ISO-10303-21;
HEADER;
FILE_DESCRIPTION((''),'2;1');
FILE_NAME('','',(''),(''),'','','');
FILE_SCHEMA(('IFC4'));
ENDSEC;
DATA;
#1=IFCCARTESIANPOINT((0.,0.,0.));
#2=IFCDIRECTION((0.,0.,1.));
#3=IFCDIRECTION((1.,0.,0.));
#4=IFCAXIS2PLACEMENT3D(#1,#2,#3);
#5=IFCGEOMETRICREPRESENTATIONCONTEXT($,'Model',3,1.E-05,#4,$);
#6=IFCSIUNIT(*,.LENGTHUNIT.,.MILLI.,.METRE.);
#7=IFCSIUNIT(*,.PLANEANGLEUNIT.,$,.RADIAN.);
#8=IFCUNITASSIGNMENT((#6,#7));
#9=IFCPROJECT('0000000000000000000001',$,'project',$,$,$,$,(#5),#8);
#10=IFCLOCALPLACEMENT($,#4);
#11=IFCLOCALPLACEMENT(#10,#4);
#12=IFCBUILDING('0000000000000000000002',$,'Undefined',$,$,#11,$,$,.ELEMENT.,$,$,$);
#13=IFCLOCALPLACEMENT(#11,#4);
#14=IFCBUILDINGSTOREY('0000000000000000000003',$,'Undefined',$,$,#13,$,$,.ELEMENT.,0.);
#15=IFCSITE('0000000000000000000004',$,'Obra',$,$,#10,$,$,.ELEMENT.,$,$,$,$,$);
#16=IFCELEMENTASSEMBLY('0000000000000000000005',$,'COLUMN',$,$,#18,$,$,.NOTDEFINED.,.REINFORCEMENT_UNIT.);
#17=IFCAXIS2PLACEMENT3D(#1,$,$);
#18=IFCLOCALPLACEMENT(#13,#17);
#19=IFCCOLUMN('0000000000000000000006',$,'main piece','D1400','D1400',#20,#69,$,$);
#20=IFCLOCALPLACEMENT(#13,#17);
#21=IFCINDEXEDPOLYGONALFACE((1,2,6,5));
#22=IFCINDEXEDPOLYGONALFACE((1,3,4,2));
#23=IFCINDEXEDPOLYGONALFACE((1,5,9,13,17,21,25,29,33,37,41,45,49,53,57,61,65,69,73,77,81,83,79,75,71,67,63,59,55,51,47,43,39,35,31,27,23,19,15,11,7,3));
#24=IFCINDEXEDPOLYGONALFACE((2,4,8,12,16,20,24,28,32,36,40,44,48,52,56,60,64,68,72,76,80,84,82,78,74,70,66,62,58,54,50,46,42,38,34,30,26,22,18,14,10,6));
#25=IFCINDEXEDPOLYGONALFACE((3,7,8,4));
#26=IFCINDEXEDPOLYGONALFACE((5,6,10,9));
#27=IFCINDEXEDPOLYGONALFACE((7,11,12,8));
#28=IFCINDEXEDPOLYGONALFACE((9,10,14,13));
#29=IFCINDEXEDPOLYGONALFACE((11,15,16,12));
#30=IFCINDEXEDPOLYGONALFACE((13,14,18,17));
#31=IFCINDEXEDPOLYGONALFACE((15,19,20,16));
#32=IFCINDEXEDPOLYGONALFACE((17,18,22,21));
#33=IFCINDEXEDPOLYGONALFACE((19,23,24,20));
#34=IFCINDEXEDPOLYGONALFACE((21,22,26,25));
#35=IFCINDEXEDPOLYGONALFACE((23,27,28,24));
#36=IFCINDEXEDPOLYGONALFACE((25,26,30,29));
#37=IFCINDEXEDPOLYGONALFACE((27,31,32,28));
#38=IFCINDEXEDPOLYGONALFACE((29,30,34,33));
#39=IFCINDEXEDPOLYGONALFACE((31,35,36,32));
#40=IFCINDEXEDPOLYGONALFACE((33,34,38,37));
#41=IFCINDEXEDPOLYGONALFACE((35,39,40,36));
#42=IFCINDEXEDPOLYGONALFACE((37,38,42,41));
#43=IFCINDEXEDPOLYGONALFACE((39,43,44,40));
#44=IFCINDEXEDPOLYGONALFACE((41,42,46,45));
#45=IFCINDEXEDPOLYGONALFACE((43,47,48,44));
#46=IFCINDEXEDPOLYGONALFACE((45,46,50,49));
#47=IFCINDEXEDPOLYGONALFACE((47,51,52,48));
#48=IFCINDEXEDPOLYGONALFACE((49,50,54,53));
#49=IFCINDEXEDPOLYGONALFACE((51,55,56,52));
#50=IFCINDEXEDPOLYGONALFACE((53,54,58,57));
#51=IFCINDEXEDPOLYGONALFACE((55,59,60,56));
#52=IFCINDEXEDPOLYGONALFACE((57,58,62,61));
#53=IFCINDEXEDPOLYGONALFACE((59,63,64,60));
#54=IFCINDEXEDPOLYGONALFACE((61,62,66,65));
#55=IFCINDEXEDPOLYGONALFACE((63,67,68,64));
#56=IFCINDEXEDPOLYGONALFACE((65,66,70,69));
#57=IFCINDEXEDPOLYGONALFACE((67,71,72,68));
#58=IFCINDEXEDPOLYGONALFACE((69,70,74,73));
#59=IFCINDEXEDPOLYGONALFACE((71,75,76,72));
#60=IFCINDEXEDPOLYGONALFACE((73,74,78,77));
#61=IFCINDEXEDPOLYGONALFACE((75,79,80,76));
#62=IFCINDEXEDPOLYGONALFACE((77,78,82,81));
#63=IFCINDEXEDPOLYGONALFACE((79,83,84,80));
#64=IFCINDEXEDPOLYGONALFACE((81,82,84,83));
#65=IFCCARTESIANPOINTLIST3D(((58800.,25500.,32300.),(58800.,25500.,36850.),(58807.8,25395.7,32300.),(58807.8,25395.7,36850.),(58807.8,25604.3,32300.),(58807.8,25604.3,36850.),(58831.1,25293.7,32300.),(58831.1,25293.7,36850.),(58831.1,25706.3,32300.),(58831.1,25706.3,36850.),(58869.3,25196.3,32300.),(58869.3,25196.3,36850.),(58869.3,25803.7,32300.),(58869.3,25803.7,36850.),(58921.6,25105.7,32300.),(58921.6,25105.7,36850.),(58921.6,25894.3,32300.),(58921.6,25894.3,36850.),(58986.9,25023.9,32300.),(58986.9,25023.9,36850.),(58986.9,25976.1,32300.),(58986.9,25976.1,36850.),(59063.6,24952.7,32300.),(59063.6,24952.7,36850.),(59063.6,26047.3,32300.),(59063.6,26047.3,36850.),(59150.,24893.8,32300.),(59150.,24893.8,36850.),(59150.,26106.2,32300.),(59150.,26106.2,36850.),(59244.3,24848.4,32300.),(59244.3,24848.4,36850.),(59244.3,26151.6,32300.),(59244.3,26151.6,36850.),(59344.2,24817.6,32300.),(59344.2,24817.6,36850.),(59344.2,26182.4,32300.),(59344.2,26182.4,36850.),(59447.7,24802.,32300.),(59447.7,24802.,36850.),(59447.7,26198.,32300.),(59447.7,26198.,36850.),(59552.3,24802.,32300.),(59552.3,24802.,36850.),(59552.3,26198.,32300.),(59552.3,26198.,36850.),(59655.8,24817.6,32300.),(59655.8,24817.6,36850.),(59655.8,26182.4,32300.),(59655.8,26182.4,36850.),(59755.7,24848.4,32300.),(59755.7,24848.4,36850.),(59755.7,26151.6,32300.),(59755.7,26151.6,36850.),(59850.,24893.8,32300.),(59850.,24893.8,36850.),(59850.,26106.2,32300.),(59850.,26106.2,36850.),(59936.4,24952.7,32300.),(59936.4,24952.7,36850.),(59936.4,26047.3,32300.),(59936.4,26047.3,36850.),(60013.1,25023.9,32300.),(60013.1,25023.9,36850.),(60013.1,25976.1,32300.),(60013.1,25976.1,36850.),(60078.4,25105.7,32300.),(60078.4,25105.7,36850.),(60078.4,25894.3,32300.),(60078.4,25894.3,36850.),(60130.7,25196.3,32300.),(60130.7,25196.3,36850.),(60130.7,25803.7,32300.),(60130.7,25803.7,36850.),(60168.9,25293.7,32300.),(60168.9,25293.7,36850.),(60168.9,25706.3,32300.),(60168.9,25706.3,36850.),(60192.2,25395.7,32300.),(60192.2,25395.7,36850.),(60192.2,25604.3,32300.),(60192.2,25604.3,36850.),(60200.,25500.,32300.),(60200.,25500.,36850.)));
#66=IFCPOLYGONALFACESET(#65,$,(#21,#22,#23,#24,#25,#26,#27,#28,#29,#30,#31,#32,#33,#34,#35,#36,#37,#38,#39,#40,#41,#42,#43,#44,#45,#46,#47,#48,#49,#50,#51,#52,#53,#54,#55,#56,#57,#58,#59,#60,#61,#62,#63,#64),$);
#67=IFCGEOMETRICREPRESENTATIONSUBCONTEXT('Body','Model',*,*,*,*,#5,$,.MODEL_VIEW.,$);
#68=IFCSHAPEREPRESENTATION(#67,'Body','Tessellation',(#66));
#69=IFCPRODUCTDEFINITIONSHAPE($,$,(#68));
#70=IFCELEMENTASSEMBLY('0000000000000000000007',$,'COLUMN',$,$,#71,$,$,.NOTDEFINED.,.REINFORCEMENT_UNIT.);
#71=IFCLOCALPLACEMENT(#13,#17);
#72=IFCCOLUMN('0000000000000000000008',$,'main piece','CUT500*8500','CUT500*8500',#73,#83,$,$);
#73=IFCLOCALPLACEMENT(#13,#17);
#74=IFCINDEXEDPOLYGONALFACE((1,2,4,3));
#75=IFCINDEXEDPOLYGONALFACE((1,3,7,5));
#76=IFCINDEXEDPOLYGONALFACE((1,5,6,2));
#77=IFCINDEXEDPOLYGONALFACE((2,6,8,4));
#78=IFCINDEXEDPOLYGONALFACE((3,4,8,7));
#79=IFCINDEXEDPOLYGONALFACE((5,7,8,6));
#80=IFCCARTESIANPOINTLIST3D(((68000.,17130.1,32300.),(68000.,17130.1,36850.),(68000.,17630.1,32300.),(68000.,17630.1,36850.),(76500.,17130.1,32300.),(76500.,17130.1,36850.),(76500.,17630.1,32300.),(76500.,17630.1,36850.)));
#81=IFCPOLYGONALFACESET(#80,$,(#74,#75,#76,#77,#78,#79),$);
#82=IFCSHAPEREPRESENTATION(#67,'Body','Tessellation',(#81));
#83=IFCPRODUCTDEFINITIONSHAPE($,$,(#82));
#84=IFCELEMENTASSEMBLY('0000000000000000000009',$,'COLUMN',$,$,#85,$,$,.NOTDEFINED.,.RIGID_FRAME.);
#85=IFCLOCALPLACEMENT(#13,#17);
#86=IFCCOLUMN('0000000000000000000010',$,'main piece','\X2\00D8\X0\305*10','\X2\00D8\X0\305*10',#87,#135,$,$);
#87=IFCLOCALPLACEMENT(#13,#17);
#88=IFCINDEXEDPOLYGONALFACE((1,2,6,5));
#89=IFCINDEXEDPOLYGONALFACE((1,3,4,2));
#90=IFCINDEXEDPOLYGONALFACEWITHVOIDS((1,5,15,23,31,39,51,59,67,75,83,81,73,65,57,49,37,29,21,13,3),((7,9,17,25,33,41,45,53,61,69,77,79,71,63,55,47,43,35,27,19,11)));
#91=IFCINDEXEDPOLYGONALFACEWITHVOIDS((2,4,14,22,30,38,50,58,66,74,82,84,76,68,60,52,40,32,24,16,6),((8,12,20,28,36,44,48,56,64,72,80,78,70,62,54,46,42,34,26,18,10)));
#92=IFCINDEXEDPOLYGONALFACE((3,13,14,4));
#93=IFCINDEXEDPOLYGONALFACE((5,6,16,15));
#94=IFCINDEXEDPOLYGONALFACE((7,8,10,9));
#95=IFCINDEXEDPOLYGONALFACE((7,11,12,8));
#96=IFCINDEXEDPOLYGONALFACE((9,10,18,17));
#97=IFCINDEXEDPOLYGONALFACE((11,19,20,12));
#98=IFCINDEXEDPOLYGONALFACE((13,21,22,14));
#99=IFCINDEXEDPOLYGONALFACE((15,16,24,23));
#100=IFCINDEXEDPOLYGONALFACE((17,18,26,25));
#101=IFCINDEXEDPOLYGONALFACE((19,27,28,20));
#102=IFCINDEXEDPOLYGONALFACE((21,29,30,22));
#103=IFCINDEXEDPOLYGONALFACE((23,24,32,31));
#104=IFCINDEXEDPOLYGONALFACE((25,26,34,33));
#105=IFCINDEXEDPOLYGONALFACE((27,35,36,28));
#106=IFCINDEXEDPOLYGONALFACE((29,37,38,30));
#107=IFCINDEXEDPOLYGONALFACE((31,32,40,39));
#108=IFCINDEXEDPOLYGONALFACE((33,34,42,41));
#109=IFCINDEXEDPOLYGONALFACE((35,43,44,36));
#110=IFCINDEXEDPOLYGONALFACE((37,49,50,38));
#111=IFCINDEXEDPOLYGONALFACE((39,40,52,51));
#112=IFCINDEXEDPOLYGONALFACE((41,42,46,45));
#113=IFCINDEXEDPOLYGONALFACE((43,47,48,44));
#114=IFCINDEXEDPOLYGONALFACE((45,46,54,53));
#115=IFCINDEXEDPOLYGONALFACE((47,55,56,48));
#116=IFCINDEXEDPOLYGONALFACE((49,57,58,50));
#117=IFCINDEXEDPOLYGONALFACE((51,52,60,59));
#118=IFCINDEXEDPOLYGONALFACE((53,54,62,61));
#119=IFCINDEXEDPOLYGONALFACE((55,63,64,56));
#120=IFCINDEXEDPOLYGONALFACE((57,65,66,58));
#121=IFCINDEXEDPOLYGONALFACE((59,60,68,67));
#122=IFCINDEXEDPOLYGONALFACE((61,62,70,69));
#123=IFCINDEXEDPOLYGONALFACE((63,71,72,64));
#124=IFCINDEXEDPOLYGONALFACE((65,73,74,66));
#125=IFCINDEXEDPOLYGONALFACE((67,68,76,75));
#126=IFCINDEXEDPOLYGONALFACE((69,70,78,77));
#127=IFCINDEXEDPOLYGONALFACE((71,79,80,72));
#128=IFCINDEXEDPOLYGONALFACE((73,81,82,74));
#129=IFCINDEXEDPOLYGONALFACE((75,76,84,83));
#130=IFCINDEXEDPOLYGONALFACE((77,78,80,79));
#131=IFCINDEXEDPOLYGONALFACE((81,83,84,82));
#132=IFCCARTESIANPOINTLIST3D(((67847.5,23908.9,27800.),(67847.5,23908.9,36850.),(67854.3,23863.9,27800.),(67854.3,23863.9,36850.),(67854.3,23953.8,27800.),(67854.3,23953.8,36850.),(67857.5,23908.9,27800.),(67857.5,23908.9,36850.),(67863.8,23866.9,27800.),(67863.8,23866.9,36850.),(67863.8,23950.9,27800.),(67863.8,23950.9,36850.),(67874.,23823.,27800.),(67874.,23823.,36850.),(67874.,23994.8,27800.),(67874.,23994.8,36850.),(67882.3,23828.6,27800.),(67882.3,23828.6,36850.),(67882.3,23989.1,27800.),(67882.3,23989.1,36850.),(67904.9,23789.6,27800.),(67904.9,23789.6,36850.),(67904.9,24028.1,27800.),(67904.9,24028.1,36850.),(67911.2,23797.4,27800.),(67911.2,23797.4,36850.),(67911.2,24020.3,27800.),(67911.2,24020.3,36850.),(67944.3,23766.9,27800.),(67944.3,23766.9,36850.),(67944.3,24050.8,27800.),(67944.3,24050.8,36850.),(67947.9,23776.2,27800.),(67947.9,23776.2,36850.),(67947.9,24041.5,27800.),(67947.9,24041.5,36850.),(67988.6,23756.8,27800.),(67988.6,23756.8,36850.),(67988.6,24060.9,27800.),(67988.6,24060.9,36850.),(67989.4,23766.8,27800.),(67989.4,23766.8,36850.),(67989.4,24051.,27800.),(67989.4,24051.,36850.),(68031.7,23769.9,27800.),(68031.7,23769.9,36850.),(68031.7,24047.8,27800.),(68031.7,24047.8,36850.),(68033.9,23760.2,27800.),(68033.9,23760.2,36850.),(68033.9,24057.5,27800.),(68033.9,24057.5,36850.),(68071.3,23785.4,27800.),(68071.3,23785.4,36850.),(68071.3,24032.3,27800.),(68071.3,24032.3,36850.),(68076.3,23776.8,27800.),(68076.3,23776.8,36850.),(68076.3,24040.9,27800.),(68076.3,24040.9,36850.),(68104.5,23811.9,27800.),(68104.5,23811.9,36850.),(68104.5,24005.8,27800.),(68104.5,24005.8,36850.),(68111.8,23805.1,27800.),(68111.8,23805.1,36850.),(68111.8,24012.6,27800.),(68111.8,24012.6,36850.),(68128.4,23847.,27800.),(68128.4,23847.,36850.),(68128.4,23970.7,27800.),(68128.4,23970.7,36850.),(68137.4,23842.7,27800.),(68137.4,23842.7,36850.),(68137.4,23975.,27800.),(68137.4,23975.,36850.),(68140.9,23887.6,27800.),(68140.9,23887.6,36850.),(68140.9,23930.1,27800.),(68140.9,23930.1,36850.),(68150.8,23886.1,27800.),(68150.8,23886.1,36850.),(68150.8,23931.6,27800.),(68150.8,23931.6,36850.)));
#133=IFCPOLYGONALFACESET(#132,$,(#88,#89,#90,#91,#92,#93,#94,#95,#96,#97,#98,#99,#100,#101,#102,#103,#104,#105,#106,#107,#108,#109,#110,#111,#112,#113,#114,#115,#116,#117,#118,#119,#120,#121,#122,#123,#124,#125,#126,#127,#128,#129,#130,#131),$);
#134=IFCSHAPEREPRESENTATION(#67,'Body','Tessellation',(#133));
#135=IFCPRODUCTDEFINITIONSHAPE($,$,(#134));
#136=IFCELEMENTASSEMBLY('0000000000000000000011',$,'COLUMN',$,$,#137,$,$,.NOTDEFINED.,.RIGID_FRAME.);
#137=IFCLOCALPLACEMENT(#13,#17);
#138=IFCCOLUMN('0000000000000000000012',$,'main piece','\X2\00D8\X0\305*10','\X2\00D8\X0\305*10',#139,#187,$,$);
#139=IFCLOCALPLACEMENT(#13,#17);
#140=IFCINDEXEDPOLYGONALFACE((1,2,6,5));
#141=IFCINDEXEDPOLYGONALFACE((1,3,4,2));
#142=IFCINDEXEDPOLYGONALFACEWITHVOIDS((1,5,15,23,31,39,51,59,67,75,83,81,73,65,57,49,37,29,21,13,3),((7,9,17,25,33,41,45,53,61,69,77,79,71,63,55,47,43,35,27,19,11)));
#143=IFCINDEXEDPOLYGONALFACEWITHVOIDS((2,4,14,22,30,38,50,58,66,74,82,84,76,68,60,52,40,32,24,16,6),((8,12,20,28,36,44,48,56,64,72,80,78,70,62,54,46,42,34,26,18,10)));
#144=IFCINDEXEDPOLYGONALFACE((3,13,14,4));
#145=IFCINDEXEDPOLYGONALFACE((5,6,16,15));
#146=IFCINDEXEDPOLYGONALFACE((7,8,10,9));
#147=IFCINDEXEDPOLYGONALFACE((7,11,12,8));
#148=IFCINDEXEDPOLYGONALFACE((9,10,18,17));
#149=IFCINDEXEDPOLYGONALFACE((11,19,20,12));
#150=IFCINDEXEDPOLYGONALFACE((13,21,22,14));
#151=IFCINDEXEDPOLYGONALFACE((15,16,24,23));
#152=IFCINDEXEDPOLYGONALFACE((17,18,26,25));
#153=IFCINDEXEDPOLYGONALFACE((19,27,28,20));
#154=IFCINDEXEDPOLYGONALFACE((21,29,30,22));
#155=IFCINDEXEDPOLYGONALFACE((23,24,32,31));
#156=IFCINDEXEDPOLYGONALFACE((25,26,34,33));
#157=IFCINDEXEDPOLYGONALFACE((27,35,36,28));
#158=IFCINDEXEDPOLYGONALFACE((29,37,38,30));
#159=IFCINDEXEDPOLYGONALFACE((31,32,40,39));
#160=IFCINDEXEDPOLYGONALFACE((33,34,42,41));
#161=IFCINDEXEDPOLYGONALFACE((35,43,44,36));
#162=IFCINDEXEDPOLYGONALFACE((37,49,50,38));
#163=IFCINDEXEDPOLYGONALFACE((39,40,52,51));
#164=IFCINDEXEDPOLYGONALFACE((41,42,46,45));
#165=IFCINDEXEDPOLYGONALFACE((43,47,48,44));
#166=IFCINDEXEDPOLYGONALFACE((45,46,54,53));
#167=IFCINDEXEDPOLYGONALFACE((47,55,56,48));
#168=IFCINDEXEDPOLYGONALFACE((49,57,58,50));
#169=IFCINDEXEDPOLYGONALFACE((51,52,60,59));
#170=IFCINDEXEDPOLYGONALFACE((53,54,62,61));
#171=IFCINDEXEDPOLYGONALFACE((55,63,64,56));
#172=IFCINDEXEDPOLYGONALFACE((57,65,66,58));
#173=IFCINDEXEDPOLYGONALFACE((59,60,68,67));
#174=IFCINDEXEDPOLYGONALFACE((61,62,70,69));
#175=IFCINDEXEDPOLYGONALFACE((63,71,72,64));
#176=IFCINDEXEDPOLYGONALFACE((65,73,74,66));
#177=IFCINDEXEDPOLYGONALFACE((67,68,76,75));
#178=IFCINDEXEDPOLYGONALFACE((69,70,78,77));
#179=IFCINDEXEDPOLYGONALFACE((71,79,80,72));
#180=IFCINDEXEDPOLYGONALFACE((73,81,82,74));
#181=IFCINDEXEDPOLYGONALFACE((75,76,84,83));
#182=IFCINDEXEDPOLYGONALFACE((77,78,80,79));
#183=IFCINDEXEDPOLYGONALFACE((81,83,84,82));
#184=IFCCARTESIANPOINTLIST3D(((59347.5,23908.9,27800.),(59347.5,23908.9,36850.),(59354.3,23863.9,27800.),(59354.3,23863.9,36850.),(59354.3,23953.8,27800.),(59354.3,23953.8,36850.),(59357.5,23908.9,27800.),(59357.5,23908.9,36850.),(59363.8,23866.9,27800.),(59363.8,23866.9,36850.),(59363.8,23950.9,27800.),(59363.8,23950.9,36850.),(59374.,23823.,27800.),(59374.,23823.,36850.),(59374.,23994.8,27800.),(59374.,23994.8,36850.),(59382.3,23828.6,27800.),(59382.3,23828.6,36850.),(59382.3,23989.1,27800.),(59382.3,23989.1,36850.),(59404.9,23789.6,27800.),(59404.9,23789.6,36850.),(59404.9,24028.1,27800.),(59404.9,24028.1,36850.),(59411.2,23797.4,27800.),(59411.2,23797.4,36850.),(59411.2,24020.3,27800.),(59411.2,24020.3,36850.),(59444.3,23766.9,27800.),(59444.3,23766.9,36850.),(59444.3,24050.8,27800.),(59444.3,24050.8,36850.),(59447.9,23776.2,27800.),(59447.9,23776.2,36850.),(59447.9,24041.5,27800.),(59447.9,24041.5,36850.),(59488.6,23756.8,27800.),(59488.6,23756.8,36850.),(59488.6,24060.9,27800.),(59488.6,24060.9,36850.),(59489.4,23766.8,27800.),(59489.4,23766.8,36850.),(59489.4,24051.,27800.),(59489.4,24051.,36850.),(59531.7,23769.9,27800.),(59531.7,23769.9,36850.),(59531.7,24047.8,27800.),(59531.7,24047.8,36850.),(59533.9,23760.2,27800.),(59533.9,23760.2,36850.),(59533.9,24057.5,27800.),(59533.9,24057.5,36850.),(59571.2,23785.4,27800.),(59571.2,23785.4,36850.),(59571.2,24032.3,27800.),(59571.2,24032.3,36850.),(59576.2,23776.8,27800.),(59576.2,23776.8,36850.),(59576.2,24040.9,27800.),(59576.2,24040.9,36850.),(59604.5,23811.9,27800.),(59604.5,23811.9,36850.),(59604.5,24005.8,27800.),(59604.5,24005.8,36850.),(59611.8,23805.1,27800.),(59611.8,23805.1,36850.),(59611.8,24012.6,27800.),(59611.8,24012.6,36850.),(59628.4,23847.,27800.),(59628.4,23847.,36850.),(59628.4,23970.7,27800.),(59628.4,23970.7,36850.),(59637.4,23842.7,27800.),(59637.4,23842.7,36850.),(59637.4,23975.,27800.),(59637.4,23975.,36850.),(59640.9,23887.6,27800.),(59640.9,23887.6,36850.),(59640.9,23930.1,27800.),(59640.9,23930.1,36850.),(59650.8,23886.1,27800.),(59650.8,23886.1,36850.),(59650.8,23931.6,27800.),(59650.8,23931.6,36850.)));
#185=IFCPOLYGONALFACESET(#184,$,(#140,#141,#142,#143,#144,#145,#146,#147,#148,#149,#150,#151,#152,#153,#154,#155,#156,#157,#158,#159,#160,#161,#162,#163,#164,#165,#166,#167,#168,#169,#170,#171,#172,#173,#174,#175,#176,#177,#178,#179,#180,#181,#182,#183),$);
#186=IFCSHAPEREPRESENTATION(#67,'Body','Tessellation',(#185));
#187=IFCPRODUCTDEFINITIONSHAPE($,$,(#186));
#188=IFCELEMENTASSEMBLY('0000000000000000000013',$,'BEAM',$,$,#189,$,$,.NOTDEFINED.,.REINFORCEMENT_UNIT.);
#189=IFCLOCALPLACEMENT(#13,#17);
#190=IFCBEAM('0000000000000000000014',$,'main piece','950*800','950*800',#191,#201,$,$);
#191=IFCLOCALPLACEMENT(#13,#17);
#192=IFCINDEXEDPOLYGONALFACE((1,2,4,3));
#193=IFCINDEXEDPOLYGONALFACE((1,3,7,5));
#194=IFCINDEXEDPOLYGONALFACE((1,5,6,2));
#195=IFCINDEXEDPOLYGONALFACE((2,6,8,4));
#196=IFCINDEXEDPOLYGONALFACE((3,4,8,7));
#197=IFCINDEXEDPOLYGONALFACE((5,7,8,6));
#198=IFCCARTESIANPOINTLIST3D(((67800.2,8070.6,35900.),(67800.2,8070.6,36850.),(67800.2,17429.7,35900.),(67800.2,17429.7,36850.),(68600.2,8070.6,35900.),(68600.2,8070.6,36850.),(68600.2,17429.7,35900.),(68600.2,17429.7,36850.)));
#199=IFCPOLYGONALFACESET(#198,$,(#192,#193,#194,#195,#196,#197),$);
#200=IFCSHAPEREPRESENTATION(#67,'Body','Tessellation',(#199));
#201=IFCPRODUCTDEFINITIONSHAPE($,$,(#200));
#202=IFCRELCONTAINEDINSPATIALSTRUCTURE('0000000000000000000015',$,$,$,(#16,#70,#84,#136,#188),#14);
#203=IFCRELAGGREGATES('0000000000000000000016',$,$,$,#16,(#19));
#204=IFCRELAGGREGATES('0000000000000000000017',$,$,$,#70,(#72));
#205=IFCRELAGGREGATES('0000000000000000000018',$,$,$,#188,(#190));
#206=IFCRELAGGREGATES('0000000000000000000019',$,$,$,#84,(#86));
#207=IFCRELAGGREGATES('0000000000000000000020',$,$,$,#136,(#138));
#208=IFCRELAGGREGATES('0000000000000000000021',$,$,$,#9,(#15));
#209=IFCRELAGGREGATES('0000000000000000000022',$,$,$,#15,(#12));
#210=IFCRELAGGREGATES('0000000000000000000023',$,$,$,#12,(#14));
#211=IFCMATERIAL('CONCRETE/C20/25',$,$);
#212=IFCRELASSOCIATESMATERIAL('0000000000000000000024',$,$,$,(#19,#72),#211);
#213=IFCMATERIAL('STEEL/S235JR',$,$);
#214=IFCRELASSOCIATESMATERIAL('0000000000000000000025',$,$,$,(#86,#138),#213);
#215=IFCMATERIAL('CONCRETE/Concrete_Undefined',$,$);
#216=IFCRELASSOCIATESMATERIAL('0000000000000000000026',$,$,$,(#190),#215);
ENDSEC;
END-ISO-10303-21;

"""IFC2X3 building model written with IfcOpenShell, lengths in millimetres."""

from ifc_helpers import new_model, si_unit, frame, origin_with_axes, origin_2d_with_axis, place, context, subcontext, project, spatial, rectangle, circle, hollow_circle, extrude, material, element, aggregate, save


model = new_model("IFC2X3")

# Units and contexts
model_context = context("Model", 3, precision=1e-05, world=origin_with_axes())
body_context = subcontext(model_context, "Body", "Model", "MODEL_VIEW")
ifc_project = project(units=[si_unit("LENGTHUNIT", "METRE", prefix="MILLI"), si_unit("PLANEANGLEUNIT", "RADIAN")], contexts=[model_context])

# Site, building, storey
site_placement = place(None, origin_with_axes())
site = spatial("IfcSite", under=ifc_project, at=site_placement, Name="Obra", CompositionType="ELEMENT")
building_placement = place(site_placement, origin_with_axes())
building = spatial("IfcBuilding", under=site, at=building_placement, Name="Undefined", CompositionType="ELEMENT")
storey_placement = place(building_placement, origin_with_axes())
storey = spatial("IfcBuildingStorey", under=building, at=storey_placement, Name="Undefined", CompositionType="ELEMENT", Elevation=0.0)

# Element assemblies, columns
assembly_1_placement = place(storey_placement, origin_with_axes())
assembly_1 = element("IfcElementAssembly", 1, at=assembly_1_placement, inside=storey, Name="COLUMN", AssemblyPlace="NOTDEFINED", PredefinedType="REINFORCEMENT_UNIT")
ifc_material_1 = material(Name="CONCRETE/C20/25")
column_1_placement = place(assembly_1_placement, frame((59500.0, 25500.0, 32300.0), z_axis=(0.0, 0.0, 1.0), x_axis=(0.0, 1.0, 0.0)))
column_1 = element("IfcColumn", 2, at=column_1_placement, material=ifc_material_1, Name="main piece", Description="D1400", ObjectType="D1400", context=body_context, shape_type="SweptSolid", body=[
    extrude(circle(Radius=700.0, at=origin_2d_with_axis()), frame((0.0, 0.0, 4550.0), z_axis=(0.0, 0.0, -1.0), x_axis=(0.0, 1.0, 0.0)), (0.0, 0.0, 1.0), 4550.0),
])
aggregate(assembly_1, [column_1])
assembly_2_placement = place(storey_placement, origin_with_axes())
assembly_2 = element("IfcElementAssembly", 3, at=assembly_2_placement, inside=storey, Name="COLUMN", AssemblyPlace="NOTDEFINED", PredefinedType="REINFORCEMENT_UNIT")
column_2_placement = place(assembly_2_placement, frame((72250.0, 17380.1, 32300.0), z_axis=(0.0, 0.0, 1.0), x_axis=(-1.0, 0.0, 0.0)))
column_2 = element("IfcColumn", 4, at=column_2_placement, material=ifc_material_1, Name="main piece", Description="CUT500*8500", ObjectType="CUT500*8500", context=body_context, shape_type="SweptSolid", body=[
    extrude(rectangle(XDim=500.0, YDim=8500.0, at=origin_2d_with_axis()), frame((0.0, 0.0, 4550.0), z_axis=(0.0, 0.0, -1.0), x_axis=(0.0, 1.0, 0.0)), (0.0, 0.0, 1.0), 4550.0),
])
aggregate(assembly_2, [column_2])
assembly_3_placement = place(storey_placement, origin_with_axes())
assembly_3 = element("IfcElementAssembly", 5, at=assembly_3_placement, inside=storey, Name="COLUMN", AssemblyPlace="NOTDEFINED", PredefinedType="RIGID_FRAME")
ifc_material_2 = material(Name="STEEL/S235JR")
column_3_placement = place(assembly_3_placement, frame((68000.0, 23908.9, 27800.0), z_axis=(0.0, 0.0, 1.0), x_axis=(0.0, 1.0, 0.0)))
column_3 = element("IfcColumn", 6, at=column_3_placement, material=ifc_material_2, Name="main piece", Description="Ø305*10", ObjectType="Ø305*10", context=body_context, shape_type="SweptSolid", body=[
    extrude(hollow_circle(Radius=152.5, WallThickness=10.0, at=origin_2d_with_axis()), frame((0.0, 0.0, 9050.0), z_axis=(0.0, 0.0, -1.0), x_axis=(0.0, 1.0, 0.0)), (0.0, 0.0, 1.0), 9050.0),
])
assembly_4_placement = place(storey_placement, origin_with_axes())
assembly_4 = element("IfcElementAssembly", 7, at=assembly_4_placement, inside=storey, Name="COLUMN", AssemblyPlace="NOTDEFINED", PredefinedType="RIGID_FRAME")
column_4_placement = place(assembly_4_placement, frame((59500.0, 23908.9, 27800.0), z_axis=(0.0, 0.0, 1.0), x_axis=(0.0, 1.0, 0.0)))
column_4 = element("IfcColumn", 8, at=column_4_placement, material=ifc_material_2, Name="main piece", Description="Ø305*10", ObjectType="Ø305*10", context=body_context, shape_type="SweptSolid", body=[
    extrude(hollow_circle(Radius=152.5, WallThickness=10.0, at=origin_2d_with_axis()), frame((0.0, 0.0, 9050.0), z_axis=(0.0, 0.0, -1.0), x_axis=(0.0, 1.0, 0.0)), (0.0, 0.0, 1.0), 9050.0),
])

# Element assembly, beam
assembly_5_placement = place(storey_placement, origin_with_axes())
assembly_5 = element("IfcElementAssembly", 9, at=assembly_5_placement, inside=storey, Name="BEAM", AssemblyPlace="NOTDEFINED", PredefinedType="REINFORCEMENT_UNIT")
ifc_material_3 = material(Name="CONCRETE/Concrete_Undefined")
beam_1_placement = place(assembly_5_placement, frame((68200.2, 17429.7, 36375.0), z_axis=(0.0, 0.0, 1.0), x_axis=(0.0, -1.0, 0.0)))
beam_1 = element("IfcBeam", 10, at=beam_1_placement, material=ifc_material_3, Name="main piece", Description="950*800", ObjectType="950*800", context=body_context, shape_type="SweptSolid", body=[
    extrude(rectangle(XDim=800.0, YDim=950.0, at=origin_2d_with_axis()), frame((9359.1, 0.0, 0.0), z_axis=(-1.0, 0.0, 0.0), x_axis=(0.0, -1.0, 0.0)), (0.0, 0.0, 1.0), 9359.0),
])
aggregate(assembly_5, [beam_1])

aggregate(assembly_3, [column_3])
aggregate(assembly_4, [column_4])

save(model, "model.ifc")
